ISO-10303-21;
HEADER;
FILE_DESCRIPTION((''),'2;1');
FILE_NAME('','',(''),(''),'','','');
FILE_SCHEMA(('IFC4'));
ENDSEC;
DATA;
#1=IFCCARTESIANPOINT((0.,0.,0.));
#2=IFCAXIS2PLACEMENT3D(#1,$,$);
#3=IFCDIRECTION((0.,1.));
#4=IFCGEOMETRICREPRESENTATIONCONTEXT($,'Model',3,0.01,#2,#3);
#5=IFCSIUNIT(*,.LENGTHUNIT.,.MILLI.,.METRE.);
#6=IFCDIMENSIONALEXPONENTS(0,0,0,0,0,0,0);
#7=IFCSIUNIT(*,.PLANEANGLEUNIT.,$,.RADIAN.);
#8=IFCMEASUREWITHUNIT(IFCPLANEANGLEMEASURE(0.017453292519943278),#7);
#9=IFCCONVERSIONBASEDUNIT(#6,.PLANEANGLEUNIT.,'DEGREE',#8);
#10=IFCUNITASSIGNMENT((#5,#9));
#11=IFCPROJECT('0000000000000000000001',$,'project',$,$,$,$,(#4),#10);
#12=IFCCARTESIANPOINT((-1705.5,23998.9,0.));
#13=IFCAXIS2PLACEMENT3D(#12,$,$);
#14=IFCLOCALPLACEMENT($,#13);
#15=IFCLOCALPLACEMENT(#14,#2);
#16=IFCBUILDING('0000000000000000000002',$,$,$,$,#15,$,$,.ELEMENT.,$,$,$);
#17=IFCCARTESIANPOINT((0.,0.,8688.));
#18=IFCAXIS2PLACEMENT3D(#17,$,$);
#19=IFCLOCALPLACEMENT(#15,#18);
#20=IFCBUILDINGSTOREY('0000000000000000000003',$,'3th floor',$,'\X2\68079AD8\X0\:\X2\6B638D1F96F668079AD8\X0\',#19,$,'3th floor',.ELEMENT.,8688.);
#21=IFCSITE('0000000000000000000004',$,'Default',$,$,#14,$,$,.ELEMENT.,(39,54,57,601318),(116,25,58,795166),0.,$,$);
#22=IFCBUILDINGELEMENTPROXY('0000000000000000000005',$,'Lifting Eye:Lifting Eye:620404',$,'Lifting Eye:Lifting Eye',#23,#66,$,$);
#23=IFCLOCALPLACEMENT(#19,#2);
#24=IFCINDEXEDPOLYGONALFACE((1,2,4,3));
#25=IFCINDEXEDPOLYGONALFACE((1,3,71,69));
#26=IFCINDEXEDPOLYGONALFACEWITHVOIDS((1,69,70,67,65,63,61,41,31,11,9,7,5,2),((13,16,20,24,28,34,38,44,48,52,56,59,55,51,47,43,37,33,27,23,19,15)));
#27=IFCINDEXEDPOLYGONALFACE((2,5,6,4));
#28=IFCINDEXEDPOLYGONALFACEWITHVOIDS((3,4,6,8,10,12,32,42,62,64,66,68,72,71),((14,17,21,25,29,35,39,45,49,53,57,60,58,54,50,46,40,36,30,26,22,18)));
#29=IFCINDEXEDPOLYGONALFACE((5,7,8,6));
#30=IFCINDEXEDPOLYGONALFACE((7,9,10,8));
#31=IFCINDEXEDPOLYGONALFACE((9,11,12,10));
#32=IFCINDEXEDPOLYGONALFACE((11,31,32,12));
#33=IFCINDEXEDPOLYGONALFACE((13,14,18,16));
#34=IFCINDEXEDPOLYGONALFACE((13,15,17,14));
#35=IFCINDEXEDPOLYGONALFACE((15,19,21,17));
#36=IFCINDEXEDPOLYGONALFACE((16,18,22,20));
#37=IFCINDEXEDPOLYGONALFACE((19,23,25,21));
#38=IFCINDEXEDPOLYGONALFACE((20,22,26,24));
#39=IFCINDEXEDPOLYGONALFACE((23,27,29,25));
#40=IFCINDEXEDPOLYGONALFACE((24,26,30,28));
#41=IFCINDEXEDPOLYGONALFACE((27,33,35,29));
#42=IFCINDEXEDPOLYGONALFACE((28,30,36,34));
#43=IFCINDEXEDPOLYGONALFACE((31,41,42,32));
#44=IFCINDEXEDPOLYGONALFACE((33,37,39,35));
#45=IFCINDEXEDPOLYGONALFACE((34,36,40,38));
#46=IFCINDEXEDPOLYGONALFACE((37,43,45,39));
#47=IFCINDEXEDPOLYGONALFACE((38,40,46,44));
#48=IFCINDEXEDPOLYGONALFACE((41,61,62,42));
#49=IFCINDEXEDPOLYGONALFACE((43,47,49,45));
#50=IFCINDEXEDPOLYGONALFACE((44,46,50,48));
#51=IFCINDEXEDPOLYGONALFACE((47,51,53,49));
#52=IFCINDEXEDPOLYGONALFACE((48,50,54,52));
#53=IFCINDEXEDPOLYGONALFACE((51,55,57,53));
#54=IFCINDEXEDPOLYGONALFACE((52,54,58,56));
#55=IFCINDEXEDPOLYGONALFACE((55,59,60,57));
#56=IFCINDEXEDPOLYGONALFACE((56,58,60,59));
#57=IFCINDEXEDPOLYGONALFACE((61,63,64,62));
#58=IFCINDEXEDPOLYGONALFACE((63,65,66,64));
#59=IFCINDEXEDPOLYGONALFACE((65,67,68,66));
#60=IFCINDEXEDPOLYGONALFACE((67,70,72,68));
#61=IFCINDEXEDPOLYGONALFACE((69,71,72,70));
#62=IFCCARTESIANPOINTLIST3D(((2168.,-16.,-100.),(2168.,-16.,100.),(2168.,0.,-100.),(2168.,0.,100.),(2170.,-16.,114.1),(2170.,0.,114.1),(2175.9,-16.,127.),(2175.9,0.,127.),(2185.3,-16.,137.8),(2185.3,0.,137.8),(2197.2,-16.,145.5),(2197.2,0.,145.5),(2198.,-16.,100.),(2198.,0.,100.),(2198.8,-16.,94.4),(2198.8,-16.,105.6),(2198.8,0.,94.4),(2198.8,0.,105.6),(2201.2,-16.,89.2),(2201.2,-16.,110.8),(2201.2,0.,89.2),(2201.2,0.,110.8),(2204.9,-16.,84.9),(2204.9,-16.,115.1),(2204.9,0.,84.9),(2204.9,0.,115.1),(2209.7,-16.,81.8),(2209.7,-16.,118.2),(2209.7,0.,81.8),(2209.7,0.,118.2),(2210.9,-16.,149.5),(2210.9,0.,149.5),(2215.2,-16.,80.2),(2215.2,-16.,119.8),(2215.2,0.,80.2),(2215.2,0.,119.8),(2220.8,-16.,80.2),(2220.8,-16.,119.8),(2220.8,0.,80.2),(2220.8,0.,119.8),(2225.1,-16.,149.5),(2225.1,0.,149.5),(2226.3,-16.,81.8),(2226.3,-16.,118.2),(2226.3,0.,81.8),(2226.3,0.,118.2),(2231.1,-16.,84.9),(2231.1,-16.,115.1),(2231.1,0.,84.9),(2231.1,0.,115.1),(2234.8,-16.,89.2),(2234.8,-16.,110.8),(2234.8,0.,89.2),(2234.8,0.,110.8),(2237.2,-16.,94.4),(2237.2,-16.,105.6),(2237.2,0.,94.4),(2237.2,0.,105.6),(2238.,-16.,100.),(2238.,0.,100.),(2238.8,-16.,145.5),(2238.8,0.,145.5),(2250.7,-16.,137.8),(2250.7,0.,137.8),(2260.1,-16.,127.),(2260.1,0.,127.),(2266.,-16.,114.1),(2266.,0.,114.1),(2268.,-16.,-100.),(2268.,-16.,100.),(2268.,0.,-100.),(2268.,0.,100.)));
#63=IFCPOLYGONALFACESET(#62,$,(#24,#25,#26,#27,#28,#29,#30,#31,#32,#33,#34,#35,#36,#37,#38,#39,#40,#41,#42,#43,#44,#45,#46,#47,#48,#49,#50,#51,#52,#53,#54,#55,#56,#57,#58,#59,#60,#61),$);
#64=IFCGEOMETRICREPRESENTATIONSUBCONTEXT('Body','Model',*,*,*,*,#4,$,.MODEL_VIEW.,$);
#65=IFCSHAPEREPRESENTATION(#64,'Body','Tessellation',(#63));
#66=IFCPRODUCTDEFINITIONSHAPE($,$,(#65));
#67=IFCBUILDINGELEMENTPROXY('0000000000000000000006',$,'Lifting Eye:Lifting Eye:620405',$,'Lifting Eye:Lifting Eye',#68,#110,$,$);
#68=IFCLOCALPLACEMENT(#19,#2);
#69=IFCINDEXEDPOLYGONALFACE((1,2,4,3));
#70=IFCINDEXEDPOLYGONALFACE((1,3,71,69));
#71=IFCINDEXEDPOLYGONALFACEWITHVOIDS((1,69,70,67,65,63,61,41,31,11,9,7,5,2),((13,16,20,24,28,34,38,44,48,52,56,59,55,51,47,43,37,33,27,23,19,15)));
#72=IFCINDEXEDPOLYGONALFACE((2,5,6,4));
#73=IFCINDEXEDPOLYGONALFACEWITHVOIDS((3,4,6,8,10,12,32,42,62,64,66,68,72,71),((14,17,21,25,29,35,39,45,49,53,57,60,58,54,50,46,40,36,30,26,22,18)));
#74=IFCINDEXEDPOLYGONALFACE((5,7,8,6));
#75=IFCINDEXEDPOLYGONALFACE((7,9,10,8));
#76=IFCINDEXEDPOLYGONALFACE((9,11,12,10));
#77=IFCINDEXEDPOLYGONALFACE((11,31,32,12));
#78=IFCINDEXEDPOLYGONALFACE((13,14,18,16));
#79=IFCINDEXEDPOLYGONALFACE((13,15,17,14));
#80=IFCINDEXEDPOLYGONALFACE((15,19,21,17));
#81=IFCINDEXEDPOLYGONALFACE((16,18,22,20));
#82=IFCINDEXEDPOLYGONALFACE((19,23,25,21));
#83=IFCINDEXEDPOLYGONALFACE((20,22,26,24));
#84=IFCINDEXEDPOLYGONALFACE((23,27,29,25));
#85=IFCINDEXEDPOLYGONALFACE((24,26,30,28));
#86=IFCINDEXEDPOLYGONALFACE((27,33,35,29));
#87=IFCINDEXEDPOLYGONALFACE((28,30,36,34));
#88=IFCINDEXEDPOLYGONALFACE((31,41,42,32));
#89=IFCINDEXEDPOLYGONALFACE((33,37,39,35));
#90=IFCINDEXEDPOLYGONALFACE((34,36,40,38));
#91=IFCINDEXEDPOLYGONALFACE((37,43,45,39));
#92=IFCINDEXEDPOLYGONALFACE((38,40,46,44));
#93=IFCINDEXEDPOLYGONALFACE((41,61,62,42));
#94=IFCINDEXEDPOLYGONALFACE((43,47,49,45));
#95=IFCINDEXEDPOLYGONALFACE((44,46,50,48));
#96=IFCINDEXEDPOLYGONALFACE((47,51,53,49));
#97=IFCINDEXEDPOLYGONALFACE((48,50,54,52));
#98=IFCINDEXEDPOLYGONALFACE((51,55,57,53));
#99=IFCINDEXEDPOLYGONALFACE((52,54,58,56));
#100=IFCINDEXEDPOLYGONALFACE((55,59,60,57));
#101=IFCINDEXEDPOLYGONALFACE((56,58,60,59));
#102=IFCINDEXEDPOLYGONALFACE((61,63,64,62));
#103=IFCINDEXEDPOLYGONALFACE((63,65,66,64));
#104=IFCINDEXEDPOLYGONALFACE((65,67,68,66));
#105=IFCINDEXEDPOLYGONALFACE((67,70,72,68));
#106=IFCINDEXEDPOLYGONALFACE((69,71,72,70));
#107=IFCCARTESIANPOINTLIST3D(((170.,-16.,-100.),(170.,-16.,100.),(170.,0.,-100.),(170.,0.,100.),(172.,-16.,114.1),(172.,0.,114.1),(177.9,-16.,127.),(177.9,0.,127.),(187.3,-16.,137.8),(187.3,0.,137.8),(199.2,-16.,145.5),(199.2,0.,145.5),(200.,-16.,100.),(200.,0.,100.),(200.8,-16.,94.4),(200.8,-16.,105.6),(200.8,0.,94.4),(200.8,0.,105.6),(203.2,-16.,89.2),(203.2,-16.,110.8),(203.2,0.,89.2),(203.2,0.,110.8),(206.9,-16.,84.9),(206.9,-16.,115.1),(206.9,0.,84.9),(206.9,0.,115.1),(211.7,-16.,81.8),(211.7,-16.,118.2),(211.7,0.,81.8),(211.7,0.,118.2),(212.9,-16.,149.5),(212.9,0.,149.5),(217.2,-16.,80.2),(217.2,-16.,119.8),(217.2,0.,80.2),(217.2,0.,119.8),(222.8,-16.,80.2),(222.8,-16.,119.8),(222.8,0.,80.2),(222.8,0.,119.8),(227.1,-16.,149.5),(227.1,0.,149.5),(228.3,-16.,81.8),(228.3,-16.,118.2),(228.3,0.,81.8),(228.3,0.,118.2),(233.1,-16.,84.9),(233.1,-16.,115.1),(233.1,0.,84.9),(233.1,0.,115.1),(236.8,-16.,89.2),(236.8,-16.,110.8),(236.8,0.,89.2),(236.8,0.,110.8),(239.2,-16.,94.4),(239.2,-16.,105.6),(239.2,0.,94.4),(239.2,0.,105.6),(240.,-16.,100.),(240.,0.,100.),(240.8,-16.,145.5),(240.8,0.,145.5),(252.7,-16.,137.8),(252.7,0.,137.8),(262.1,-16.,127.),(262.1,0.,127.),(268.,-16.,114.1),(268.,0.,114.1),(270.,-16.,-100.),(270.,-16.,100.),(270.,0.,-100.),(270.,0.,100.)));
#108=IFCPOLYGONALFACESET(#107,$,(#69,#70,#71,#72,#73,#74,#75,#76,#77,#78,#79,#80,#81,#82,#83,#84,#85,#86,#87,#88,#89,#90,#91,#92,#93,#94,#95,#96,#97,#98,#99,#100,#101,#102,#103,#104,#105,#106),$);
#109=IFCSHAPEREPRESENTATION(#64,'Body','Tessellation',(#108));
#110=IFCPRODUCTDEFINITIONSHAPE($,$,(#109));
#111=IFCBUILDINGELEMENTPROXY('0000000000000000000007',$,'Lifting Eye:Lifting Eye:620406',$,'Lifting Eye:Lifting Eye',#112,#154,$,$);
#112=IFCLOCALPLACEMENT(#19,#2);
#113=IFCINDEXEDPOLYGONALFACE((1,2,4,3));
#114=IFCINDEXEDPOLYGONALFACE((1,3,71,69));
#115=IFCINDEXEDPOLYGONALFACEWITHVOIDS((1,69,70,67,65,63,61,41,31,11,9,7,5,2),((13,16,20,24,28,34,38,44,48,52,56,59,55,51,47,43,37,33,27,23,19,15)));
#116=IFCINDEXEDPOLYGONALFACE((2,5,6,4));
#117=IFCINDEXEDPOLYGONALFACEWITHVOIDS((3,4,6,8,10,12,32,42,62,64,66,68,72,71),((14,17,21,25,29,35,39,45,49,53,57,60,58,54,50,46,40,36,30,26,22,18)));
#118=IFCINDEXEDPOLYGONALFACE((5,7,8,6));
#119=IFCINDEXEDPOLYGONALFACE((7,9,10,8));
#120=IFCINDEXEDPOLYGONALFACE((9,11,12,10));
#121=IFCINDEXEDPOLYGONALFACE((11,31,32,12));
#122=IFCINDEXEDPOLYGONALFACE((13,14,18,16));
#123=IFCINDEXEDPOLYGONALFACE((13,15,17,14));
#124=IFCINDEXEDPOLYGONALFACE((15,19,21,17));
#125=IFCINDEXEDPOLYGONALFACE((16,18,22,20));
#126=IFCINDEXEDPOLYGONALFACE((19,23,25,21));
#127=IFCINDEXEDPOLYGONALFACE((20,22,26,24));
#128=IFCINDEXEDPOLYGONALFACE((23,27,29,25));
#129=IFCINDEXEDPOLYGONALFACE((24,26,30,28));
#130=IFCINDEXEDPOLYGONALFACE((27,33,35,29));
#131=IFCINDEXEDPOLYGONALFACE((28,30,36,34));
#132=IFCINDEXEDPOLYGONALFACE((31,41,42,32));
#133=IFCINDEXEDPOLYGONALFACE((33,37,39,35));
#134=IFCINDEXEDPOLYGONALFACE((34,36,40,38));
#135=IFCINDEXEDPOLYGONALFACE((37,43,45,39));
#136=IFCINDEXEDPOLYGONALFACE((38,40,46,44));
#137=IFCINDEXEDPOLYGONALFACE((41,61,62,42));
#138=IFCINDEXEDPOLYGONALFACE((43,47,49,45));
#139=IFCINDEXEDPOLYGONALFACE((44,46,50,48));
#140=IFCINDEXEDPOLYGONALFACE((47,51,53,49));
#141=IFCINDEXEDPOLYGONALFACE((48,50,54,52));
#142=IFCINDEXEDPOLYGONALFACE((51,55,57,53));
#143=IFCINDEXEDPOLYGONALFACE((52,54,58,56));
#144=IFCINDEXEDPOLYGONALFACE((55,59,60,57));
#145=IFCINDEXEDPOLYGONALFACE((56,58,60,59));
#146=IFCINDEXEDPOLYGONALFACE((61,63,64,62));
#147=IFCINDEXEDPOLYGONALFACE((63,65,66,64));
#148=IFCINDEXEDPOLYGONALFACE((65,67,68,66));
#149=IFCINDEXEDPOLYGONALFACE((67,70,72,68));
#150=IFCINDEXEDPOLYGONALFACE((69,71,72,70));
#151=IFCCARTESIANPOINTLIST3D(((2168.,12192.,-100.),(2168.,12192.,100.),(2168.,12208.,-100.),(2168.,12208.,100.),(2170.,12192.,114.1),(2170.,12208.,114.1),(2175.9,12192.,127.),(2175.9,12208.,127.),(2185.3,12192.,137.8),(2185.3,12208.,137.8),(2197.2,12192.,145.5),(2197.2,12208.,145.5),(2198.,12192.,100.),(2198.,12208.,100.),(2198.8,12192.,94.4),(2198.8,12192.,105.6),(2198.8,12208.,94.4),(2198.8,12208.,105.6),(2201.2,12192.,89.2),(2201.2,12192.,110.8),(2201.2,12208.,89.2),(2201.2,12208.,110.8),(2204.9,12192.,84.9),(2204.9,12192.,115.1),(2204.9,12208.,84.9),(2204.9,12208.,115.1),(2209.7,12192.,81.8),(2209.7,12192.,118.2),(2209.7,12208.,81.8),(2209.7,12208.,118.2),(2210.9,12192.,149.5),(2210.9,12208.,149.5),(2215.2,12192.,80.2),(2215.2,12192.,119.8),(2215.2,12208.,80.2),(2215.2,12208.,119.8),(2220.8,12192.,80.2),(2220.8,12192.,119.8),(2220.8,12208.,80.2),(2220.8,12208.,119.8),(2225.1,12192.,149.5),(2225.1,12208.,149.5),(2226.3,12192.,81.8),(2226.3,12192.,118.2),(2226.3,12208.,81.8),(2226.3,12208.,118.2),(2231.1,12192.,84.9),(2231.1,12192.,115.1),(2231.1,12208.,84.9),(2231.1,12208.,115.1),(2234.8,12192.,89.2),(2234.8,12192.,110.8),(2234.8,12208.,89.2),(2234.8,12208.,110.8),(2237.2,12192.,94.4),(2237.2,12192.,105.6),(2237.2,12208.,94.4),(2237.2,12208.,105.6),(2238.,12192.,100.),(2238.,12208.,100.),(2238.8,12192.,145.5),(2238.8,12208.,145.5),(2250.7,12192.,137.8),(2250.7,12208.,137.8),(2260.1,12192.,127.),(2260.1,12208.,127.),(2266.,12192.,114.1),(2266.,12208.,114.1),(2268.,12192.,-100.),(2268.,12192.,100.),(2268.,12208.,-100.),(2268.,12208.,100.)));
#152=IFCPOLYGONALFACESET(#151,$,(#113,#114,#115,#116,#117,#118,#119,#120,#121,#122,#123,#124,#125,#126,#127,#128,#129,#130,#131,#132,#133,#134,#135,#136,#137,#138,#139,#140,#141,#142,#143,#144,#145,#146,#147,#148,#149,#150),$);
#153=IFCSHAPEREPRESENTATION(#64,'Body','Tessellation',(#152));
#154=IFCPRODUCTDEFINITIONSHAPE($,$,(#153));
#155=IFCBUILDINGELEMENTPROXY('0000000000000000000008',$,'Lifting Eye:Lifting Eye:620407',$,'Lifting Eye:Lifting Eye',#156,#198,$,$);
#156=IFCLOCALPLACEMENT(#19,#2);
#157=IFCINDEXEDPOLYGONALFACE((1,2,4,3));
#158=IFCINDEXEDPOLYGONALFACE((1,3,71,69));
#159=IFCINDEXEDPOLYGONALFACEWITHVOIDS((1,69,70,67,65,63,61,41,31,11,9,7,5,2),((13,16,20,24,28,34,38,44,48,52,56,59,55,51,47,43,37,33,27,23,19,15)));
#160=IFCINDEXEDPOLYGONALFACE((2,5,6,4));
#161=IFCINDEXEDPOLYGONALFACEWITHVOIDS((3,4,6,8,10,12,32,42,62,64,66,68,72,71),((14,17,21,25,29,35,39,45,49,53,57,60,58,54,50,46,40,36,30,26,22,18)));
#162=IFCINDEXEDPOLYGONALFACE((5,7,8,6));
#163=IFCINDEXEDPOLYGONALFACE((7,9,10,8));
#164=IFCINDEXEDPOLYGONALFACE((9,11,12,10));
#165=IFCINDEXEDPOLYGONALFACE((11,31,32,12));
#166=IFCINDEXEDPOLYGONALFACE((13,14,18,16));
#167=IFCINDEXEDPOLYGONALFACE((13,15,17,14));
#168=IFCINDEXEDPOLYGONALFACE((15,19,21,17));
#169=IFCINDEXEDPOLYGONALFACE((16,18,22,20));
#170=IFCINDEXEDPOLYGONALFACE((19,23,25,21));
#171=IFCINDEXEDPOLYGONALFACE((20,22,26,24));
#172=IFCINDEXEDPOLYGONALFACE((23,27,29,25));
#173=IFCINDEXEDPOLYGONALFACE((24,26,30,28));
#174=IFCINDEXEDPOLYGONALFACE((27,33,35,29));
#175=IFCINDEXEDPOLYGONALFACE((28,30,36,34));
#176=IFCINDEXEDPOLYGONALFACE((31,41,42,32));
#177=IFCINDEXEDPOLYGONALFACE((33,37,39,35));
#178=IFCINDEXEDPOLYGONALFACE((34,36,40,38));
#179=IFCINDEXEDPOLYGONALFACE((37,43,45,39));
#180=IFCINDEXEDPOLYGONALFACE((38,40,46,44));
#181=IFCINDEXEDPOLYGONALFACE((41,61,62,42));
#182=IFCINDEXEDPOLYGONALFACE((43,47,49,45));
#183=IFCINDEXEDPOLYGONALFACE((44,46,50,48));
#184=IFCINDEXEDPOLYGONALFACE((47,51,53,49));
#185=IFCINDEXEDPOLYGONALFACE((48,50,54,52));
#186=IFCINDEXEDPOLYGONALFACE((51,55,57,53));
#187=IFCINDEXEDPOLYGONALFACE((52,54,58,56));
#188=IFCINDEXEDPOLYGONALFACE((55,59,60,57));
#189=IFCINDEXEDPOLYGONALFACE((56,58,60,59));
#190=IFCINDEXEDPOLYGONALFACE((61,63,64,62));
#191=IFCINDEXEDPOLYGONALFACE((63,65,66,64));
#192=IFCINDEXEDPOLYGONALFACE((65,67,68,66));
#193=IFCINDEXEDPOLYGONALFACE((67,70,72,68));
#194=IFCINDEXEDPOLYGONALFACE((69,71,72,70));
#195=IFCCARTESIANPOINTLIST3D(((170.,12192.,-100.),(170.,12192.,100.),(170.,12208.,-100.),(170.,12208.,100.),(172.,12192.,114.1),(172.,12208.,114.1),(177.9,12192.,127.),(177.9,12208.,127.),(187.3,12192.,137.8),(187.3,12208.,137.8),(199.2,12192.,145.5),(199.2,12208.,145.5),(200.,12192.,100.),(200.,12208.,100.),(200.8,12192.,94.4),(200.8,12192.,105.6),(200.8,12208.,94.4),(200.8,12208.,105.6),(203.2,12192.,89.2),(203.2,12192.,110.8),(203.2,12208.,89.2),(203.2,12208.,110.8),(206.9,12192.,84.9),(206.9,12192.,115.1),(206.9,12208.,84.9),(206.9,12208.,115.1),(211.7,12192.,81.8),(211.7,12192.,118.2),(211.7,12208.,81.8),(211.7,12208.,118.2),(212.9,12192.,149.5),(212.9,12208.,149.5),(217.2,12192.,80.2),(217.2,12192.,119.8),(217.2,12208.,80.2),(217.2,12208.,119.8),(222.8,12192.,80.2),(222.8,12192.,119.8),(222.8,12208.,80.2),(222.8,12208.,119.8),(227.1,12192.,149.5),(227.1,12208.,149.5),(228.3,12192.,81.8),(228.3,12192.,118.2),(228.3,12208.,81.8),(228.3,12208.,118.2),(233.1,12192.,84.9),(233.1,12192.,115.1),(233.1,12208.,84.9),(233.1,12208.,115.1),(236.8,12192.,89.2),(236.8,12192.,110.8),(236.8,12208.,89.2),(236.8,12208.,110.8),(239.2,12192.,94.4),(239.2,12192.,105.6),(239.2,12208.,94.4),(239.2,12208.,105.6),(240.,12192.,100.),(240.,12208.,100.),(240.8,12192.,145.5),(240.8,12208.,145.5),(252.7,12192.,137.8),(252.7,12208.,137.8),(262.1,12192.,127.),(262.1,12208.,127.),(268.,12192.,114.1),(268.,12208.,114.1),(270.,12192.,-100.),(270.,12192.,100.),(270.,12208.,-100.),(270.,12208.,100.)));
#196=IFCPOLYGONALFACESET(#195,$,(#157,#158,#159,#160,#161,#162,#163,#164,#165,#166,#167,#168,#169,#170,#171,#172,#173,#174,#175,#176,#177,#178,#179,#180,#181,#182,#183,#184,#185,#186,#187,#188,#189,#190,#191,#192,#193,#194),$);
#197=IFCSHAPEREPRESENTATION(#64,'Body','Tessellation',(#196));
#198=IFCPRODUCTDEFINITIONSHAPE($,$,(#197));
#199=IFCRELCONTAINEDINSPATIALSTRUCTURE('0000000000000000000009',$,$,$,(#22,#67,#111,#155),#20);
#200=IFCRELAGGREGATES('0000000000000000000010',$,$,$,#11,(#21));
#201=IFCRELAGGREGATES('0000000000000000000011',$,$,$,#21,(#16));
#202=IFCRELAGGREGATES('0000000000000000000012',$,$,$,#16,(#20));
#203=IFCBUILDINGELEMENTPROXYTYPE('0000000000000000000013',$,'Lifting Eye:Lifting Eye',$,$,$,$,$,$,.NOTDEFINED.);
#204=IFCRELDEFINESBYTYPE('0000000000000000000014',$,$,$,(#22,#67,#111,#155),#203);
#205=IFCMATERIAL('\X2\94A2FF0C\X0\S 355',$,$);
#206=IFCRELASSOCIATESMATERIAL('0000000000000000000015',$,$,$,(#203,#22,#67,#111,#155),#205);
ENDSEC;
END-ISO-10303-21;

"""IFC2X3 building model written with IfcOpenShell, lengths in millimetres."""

from ifc_helpers import new_model, entity, si_unit, converted_unit, direction, frame, frame_2d, origin, place, context, subcontext, project, spatial, polyline, circle_curve, parameter, trimmed, segment, composite_curve, outline, extrude, source, transform, mapped, material, type_object, type_shapes, element, save


model = new_model("IFC2X3")

# Units and contexts
model_context = context("Model", 3, precision=0.01, world=origin(), true_north=direction((0.0, 1.0)))
body_context = subcontext(model_context, "Body", "Model", "MODEL_VIEW")
ifc_project = project(units=[si_unit("LENGTHUNIT", "METRE", prefix="MILLI"), converted_unit("PLANEANGLEUNIT", "DEGREE", entity("IfcPlaneAngleMeasure", 0.017453292519943278), si_unit("PLANEANGLEUNIT", "RADIAN"), dimensions=[0, 0, 0, 0, 0, 0, 0])], contexts=[model_context])

# Site, building, storey
site_placement = place(None, frame((-1705.5, 23998.9, 0.0)))
site = spatial("IfcSite", under=ifc_project, at=site_placement, Name="Default", CompositionType="ELEMENT", RefLatitude=(39, 54, 57, 601318), RefLongitude=(116, 25, 58, 795166), RefElevation=0.0)
building_placement = place(site_placement, origin())
building = spatial("IfcBuilding", under=site, at=building_placement, CompositionType="ELEMENT")
storey_placement = place(building_placement, frame((0.0, 0.0, 8688.0)))
storey = spatial("IfcBuildingStorey", under=building, at=storey_placement, Name="3th floor", ObjectType="标高:正负零标高", LongName="3th floor", CompositionType="ELEMENT", Elevation=8688.0)

# Building element proxies
ifc_material_1 = material(Name="钢，S 355")
building_element_proxy_type_1 = type_object("IfcBuildingElementProxyType", Name="Lifting Eye:Lifting Eye", PredefinedType="NOTDEFINED", material=ifc_material_1)
shared_shape_1 = source(origin(), body_context, "Body", "SweptSolid", [
    extrude(outline(composite_curve([segment(polyline([(-100.0, -50.0), (100.0, -50.0)]), True, "CONTINUOUS"), segment(polyline([(100.0, -50.0), (100.0, 50.0)]), True, "CONTINUOUS"), segment(polyline([(100.0, 50.0), (-100.0, 50.0)]), True, "CONTINUOUS"), segment(trimmed(circle_curve(frame_2d((-100.0, 0.0), x_axis=(0.0, -1.0)), 50.0), [parameter(180.0)], [parameter(0.0)], True, "PARAMETER"), True, "CONTINUOUS")], self_intersect=False), holes=[composite_curve([segment(trimmed(circle_curve(frame_2d((-100.0, 0.0), x_axis=(0.0, -1.0)), 20.0), [parameter(180.0)], [parameter(360.0)], True, "PARAMETER"), False, "CONTINUOUS"), segment(trimmed(circle_curve(frame_2d((-100.0, 0.0), x_axis=(0.0, -1.0)), 20.0), [parameter(0.0)], [parameter(180.0)], True, "PARAMETER"), False, "CONTINUOUS")], self_intersect=False)]), frame((0.0, 17.0, -17.0), z_axis=(0.0, 1.0, 0.0), x_axis=(0.0, 0.0, -1.0)), (0.0, 0.0, 1.0), 16.0),
])
type_shapes(building_element_proxy_type_1, [shared_shape_1])
for number, where, name in (
    (1, (2218.0, -33.0, 17.0), "Lifting Eye:Lifting Eye:620404"),
    (2, (220.0, -33.0, 17.0), "Lifting Eye:Lifting Eye:620405"),
    (3, (2218.0, 12175.0, 17.0), "Lifting Eye:Lifting Eye:620406"),
    (4, (220.0, 12175.0, 17.0), "Lifting Eye:Lifting Eye:620407"),
):
    element("IfcBuildingElementProxy", number, at=place(storey_placement, frame(where)), inside=storey, type_object=building_element_proxy_type_1, material=ifc_material_1, Name=name, ObjectType="Lifting Eye:Lifting Eye", context=body_context, shape_type="MappedRepresentation", body=[
        mapped(shared_shape_1, transform((0.0, 0.0, 0.0), scale=1.0)),
    ])

save(model, "model.ifc")
